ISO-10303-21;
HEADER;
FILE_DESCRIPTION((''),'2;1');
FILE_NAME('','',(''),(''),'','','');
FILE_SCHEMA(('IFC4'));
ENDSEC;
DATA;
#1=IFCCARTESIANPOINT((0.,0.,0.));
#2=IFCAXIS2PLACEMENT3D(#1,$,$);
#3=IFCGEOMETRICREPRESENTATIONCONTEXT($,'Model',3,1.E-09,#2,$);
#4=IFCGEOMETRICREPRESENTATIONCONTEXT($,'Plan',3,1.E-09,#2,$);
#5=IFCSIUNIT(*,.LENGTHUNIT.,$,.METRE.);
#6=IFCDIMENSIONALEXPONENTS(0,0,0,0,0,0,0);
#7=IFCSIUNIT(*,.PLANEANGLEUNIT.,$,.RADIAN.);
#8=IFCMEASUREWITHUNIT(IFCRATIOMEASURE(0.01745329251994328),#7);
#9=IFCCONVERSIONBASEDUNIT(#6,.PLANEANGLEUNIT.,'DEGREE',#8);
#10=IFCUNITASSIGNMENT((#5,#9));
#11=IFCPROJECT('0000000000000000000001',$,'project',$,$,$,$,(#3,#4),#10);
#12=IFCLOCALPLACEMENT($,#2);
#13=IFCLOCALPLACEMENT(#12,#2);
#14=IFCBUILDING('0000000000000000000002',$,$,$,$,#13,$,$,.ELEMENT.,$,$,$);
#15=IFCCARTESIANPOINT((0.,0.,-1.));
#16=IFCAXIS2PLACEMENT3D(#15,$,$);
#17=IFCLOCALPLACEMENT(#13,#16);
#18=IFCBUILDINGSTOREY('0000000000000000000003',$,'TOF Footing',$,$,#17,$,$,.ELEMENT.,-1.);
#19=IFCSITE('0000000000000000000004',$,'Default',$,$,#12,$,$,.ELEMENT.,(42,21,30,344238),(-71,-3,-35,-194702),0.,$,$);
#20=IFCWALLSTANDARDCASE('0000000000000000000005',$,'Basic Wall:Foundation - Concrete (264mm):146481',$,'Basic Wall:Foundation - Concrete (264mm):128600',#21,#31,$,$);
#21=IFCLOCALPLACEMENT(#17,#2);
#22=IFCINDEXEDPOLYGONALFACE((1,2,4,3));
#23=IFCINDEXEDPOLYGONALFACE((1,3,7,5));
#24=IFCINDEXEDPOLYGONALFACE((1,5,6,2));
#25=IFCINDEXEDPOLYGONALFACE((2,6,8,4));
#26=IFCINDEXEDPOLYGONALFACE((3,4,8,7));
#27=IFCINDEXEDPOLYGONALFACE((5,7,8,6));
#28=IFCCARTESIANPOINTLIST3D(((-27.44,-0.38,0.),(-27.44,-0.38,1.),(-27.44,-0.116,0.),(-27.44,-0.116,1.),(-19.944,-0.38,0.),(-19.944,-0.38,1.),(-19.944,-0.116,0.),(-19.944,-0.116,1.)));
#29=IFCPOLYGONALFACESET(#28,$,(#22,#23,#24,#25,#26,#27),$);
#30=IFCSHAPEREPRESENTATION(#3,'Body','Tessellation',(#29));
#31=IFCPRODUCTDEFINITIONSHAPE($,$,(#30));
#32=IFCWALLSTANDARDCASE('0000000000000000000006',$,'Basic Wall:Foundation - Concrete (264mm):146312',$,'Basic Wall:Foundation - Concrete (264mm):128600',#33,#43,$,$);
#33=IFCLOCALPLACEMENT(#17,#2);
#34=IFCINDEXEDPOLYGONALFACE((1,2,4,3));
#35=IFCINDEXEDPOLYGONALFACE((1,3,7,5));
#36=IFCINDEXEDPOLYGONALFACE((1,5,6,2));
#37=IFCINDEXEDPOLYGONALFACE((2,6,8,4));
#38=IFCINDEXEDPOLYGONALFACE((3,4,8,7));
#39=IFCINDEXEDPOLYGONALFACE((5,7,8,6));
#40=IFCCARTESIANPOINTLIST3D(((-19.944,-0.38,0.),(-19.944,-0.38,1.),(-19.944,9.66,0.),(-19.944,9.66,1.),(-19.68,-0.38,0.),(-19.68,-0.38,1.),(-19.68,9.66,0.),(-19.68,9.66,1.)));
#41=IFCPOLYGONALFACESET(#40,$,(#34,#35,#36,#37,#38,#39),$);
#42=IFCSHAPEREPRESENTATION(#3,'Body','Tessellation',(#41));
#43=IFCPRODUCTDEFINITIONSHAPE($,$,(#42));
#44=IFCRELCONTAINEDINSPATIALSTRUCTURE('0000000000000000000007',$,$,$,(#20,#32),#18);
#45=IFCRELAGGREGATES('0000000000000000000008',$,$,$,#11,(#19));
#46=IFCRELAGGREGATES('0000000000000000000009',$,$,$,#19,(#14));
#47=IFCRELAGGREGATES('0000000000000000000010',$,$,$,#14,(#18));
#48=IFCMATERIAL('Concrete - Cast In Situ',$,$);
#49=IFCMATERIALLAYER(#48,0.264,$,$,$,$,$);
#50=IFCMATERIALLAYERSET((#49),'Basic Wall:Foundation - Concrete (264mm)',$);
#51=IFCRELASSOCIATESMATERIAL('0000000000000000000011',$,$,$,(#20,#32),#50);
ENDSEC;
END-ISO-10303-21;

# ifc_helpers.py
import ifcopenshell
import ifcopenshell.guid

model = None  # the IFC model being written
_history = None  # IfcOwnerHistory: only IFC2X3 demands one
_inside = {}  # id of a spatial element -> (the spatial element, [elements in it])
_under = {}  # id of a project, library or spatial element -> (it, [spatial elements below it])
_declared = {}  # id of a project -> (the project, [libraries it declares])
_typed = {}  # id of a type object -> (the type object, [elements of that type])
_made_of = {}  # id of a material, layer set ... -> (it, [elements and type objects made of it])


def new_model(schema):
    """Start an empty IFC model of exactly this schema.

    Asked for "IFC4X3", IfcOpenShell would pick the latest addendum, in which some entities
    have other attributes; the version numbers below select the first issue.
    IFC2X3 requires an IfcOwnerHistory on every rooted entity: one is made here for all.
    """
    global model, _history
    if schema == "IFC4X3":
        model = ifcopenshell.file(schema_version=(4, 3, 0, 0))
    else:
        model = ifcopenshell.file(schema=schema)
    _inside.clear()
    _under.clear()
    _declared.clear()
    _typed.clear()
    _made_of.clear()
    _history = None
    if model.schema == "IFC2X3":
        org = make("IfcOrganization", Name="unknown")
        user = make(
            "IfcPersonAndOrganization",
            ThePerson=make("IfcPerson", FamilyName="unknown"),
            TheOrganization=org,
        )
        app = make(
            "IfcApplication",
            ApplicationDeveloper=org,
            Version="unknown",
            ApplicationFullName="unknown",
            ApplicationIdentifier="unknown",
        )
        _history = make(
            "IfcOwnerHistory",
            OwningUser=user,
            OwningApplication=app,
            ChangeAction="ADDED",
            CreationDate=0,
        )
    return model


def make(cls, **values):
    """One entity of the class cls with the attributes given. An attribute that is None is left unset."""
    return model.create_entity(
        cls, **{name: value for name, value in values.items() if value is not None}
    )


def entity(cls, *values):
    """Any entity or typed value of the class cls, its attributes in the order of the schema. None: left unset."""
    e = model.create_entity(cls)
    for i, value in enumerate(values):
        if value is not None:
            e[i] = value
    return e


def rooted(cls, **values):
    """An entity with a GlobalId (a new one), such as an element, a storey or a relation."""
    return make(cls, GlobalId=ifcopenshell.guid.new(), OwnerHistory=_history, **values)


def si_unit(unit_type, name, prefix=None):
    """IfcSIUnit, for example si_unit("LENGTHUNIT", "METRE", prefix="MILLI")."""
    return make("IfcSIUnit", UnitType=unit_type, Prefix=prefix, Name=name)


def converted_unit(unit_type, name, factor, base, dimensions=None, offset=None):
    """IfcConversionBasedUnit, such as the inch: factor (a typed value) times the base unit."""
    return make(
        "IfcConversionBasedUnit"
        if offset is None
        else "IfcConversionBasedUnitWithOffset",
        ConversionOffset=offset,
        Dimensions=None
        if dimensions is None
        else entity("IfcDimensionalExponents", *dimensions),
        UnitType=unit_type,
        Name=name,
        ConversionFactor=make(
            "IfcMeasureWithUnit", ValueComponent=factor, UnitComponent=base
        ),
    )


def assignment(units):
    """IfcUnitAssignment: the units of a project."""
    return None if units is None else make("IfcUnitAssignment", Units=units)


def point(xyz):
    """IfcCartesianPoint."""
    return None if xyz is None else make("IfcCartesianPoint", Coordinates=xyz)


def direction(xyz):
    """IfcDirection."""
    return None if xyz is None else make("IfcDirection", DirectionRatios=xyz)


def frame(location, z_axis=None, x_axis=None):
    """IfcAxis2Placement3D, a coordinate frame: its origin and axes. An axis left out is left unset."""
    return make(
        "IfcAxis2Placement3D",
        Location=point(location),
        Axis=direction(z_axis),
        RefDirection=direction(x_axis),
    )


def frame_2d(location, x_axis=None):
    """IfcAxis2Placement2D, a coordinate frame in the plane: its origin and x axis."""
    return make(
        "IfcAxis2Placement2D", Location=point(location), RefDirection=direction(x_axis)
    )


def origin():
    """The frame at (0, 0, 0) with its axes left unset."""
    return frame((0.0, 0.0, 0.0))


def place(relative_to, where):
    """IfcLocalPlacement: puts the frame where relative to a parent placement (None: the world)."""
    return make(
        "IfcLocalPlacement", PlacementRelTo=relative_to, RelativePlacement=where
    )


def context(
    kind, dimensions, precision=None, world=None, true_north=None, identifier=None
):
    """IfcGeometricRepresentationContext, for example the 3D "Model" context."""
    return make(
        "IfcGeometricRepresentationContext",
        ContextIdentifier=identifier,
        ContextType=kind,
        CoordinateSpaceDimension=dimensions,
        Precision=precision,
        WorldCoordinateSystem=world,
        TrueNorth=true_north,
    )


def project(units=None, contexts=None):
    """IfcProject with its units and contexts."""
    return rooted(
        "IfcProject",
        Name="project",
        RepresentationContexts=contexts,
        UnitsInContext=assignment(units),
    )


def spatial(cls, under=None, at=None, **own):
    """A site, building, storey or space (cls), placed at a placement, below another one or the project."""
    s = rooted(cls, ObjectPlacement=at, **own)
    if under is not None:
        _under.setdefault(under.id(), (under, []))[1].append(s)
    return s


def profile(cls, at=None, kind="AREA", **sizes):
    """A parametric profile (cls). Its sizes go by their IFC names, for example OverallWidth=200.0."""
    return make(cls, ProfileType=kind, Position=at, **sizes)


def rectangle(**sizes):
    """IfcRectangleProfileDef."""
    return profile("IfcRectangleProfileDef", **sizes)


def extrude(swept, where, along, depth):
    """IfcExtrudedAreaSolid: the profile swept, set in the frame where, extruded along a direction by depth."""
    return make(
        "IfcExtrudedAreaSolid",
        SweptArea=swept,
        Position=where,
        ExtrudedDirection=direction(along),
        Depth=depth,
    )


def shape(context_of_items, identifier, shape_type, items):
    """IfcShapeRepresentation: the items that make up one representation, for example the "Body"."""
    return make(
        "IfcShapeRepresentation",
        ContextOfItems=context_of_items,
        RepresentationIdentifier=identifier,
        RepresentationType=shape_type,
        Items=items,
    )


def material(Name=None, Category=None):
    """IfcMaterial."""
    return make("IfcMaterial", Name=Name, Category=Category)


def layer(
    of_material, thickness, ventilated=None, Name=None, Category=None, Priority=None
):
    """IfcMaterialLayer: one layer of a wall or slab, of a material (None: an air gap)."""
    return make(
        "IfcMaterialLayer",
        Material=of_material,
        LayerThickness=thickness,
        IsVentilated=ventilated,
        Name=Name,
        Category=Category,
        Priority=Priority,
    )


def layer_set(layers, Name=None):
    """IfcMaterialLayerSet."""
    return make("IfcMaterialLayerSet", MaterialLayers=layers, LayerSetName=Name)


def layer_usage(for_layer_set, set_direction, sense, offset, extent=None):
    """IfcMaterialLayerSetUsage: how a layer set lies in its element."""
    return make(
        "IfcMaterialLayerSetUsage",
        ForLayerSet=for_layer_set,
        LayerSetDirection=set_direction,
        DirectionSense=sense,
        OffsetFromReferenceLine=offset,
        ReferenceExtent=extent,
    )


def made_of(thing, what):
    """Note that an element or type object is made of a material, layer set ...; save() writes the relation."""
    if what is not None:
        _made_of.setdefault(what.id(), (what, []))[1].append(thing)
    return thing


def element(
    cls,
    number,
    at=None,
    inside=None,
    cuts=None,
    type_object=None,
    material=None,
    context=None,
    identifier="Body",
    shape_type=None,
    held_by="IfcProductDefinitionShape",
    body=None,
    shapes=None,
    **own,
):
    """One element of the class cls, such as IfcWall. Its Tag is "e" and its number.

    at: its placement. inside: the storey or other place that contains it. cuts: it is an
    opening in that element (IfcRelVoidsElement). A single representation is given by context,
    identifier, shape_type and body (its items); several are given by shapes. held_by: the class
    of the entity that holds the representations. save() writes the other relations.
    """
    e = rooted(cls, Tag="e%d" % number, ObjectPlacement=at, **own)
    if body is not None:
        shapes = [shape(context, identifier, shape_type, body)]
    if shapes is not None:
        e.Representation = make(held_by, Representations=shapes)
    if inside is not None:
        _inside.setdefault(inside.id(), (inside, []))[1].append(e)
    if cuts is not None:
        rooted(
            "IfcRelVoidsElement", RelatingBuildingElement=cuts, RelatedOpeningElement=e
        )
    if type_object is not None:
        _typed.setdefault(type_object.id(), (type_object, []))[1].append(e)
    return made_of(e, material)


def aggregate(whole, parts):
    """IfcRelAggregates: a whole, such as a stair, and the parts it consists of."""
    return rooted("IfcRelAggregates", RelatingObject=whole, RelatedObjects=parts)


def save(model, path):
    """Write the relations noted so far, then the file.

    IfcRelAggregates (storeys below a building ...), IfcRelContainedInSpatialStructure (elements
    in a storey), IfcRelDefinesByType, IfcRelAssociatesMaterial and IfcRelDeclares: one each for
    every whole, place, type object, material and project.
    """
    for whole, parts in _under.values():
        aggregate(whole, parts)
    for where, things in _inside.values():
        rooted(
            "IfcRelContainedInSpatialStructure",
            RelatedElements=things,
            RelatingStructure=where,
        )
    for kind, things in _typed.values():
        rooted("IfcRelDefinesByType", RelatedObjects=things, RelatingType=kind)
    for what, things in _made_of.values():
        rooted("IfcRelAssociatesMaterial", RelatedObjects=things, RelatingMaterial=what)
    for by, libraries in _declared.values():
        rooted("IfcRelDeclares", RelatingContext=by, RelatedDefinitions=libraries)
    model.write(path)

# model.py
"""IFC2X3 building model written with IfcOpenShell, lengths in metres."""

from ifc_helpers import new_model, entity, si_unit, converted_unit, frame, frame_2d, origin, place, context, project, spatial, rectangle, extrude, material, layer, layer_set, layer_usage, element, save


model = new_model("IFC2X3")

# Units and contexts
model_context = context("Model", 3, precision=1e-09, world=origin())
plan_context = context("Plan", 3, precision=1e-09, world=origin())
ifc_project = project(units=[si_unit("LENGTHUNIT", "METRE"), converted_unit("PLANEANGLEUNIT", "DEGREE", entity("IfcRatioMeasure", 0.01745329251994328), si_unit("PLANEANGLEUNIT", "RADIAN"), dimensions=[0, 0, 0, 0, 0, 0, 0])], contexts=[model_context, plan_context])

# Site, building, storey
site_placement = place(None, origin())
site = spatial("IfcSite", under=ifc_project, at=site_placement, Name="Default", CompositionType="ELEMENT", RefLatitude=(42, 21, 30, 344238), RefLongitude=(-71, -3, -35, -194702), RefElevation=0.0)
building_placement = place(site_placement, origin())
building = spatial("IfcBuilding", under=site, at=building_placement, CompositionType="ELEMENT")
storey_placement = place(building_placement, frame((0.0, 0.0, -1.0)))
storey = spatial("IfcBuildingStorey", under=building, at=storey_placement, Name="TOF Footing", CompositionType="ELEMENT", Elevation=-1.0)

# Walls
ifc_material_1 = material(Name="Concrete - Cast In Situ")
ifc_layer = layer(ifc_material_1, 0.264)
ifc_layer_set = layer_set([ifc_layer], Name="Basic Wall:Foundation - Concrete (264mm)")
ifc_layer_usage = layer_usage(ifc_layer_set, "AXIS2", "NEGATIVE", 0.132)
wall_1_placement = place(storey_placement, frame((-19.944, -0.248, 0.0), z_axis=(0.0, 0.0, 1.0), x_axis=(-1.0, 0.0, 0.0)))
element("IfcWallStandardCase", 1, at=wall_1_placement, inside=storey, material=ifc_layer_usage, Name="Basic Wall:Foundation - Concrete (264mm):146481", ObjectType="Basic Wall:Foundation - Concrete (264mm):128600", context=model_context, shape_type="SweptSolid", body=[
    extrude(rectangle(XDim=7.496, YDim=0.264, at=frame_2d((3.748, 0.0), x_axis=(-1.0, 0.0))), origin(), (0.0, 0.0, 1.0), 1.0),
])
wall_2_placement = place(storey_placement, frame((-19.812, 9.66, 0.0), z_axis=(0.0, 0.0, 1.0), x_axis=(0.0, -1.0, 0.0)))
element("IfcWallStandardCase", 2, at=wall_2_placement, inside=storey, material=ifc_layer_usage, Name="Basic Wall:Foundation - Concrete (264mm):146312", ObjectType="Basic Wall:Foundation - Concrete (264mm):128600", context=model_context, shape_type="SweptSolid", body=[
    extrude(rectangle(XDim=10.04, YDim=0.264, at=frame_2d((5.02, 0.0), x_axis=(-1.0, 0.0))), origin(), (0.0, 0.0, 1.0), 1.0),
])

save(model, "model.ifc")
